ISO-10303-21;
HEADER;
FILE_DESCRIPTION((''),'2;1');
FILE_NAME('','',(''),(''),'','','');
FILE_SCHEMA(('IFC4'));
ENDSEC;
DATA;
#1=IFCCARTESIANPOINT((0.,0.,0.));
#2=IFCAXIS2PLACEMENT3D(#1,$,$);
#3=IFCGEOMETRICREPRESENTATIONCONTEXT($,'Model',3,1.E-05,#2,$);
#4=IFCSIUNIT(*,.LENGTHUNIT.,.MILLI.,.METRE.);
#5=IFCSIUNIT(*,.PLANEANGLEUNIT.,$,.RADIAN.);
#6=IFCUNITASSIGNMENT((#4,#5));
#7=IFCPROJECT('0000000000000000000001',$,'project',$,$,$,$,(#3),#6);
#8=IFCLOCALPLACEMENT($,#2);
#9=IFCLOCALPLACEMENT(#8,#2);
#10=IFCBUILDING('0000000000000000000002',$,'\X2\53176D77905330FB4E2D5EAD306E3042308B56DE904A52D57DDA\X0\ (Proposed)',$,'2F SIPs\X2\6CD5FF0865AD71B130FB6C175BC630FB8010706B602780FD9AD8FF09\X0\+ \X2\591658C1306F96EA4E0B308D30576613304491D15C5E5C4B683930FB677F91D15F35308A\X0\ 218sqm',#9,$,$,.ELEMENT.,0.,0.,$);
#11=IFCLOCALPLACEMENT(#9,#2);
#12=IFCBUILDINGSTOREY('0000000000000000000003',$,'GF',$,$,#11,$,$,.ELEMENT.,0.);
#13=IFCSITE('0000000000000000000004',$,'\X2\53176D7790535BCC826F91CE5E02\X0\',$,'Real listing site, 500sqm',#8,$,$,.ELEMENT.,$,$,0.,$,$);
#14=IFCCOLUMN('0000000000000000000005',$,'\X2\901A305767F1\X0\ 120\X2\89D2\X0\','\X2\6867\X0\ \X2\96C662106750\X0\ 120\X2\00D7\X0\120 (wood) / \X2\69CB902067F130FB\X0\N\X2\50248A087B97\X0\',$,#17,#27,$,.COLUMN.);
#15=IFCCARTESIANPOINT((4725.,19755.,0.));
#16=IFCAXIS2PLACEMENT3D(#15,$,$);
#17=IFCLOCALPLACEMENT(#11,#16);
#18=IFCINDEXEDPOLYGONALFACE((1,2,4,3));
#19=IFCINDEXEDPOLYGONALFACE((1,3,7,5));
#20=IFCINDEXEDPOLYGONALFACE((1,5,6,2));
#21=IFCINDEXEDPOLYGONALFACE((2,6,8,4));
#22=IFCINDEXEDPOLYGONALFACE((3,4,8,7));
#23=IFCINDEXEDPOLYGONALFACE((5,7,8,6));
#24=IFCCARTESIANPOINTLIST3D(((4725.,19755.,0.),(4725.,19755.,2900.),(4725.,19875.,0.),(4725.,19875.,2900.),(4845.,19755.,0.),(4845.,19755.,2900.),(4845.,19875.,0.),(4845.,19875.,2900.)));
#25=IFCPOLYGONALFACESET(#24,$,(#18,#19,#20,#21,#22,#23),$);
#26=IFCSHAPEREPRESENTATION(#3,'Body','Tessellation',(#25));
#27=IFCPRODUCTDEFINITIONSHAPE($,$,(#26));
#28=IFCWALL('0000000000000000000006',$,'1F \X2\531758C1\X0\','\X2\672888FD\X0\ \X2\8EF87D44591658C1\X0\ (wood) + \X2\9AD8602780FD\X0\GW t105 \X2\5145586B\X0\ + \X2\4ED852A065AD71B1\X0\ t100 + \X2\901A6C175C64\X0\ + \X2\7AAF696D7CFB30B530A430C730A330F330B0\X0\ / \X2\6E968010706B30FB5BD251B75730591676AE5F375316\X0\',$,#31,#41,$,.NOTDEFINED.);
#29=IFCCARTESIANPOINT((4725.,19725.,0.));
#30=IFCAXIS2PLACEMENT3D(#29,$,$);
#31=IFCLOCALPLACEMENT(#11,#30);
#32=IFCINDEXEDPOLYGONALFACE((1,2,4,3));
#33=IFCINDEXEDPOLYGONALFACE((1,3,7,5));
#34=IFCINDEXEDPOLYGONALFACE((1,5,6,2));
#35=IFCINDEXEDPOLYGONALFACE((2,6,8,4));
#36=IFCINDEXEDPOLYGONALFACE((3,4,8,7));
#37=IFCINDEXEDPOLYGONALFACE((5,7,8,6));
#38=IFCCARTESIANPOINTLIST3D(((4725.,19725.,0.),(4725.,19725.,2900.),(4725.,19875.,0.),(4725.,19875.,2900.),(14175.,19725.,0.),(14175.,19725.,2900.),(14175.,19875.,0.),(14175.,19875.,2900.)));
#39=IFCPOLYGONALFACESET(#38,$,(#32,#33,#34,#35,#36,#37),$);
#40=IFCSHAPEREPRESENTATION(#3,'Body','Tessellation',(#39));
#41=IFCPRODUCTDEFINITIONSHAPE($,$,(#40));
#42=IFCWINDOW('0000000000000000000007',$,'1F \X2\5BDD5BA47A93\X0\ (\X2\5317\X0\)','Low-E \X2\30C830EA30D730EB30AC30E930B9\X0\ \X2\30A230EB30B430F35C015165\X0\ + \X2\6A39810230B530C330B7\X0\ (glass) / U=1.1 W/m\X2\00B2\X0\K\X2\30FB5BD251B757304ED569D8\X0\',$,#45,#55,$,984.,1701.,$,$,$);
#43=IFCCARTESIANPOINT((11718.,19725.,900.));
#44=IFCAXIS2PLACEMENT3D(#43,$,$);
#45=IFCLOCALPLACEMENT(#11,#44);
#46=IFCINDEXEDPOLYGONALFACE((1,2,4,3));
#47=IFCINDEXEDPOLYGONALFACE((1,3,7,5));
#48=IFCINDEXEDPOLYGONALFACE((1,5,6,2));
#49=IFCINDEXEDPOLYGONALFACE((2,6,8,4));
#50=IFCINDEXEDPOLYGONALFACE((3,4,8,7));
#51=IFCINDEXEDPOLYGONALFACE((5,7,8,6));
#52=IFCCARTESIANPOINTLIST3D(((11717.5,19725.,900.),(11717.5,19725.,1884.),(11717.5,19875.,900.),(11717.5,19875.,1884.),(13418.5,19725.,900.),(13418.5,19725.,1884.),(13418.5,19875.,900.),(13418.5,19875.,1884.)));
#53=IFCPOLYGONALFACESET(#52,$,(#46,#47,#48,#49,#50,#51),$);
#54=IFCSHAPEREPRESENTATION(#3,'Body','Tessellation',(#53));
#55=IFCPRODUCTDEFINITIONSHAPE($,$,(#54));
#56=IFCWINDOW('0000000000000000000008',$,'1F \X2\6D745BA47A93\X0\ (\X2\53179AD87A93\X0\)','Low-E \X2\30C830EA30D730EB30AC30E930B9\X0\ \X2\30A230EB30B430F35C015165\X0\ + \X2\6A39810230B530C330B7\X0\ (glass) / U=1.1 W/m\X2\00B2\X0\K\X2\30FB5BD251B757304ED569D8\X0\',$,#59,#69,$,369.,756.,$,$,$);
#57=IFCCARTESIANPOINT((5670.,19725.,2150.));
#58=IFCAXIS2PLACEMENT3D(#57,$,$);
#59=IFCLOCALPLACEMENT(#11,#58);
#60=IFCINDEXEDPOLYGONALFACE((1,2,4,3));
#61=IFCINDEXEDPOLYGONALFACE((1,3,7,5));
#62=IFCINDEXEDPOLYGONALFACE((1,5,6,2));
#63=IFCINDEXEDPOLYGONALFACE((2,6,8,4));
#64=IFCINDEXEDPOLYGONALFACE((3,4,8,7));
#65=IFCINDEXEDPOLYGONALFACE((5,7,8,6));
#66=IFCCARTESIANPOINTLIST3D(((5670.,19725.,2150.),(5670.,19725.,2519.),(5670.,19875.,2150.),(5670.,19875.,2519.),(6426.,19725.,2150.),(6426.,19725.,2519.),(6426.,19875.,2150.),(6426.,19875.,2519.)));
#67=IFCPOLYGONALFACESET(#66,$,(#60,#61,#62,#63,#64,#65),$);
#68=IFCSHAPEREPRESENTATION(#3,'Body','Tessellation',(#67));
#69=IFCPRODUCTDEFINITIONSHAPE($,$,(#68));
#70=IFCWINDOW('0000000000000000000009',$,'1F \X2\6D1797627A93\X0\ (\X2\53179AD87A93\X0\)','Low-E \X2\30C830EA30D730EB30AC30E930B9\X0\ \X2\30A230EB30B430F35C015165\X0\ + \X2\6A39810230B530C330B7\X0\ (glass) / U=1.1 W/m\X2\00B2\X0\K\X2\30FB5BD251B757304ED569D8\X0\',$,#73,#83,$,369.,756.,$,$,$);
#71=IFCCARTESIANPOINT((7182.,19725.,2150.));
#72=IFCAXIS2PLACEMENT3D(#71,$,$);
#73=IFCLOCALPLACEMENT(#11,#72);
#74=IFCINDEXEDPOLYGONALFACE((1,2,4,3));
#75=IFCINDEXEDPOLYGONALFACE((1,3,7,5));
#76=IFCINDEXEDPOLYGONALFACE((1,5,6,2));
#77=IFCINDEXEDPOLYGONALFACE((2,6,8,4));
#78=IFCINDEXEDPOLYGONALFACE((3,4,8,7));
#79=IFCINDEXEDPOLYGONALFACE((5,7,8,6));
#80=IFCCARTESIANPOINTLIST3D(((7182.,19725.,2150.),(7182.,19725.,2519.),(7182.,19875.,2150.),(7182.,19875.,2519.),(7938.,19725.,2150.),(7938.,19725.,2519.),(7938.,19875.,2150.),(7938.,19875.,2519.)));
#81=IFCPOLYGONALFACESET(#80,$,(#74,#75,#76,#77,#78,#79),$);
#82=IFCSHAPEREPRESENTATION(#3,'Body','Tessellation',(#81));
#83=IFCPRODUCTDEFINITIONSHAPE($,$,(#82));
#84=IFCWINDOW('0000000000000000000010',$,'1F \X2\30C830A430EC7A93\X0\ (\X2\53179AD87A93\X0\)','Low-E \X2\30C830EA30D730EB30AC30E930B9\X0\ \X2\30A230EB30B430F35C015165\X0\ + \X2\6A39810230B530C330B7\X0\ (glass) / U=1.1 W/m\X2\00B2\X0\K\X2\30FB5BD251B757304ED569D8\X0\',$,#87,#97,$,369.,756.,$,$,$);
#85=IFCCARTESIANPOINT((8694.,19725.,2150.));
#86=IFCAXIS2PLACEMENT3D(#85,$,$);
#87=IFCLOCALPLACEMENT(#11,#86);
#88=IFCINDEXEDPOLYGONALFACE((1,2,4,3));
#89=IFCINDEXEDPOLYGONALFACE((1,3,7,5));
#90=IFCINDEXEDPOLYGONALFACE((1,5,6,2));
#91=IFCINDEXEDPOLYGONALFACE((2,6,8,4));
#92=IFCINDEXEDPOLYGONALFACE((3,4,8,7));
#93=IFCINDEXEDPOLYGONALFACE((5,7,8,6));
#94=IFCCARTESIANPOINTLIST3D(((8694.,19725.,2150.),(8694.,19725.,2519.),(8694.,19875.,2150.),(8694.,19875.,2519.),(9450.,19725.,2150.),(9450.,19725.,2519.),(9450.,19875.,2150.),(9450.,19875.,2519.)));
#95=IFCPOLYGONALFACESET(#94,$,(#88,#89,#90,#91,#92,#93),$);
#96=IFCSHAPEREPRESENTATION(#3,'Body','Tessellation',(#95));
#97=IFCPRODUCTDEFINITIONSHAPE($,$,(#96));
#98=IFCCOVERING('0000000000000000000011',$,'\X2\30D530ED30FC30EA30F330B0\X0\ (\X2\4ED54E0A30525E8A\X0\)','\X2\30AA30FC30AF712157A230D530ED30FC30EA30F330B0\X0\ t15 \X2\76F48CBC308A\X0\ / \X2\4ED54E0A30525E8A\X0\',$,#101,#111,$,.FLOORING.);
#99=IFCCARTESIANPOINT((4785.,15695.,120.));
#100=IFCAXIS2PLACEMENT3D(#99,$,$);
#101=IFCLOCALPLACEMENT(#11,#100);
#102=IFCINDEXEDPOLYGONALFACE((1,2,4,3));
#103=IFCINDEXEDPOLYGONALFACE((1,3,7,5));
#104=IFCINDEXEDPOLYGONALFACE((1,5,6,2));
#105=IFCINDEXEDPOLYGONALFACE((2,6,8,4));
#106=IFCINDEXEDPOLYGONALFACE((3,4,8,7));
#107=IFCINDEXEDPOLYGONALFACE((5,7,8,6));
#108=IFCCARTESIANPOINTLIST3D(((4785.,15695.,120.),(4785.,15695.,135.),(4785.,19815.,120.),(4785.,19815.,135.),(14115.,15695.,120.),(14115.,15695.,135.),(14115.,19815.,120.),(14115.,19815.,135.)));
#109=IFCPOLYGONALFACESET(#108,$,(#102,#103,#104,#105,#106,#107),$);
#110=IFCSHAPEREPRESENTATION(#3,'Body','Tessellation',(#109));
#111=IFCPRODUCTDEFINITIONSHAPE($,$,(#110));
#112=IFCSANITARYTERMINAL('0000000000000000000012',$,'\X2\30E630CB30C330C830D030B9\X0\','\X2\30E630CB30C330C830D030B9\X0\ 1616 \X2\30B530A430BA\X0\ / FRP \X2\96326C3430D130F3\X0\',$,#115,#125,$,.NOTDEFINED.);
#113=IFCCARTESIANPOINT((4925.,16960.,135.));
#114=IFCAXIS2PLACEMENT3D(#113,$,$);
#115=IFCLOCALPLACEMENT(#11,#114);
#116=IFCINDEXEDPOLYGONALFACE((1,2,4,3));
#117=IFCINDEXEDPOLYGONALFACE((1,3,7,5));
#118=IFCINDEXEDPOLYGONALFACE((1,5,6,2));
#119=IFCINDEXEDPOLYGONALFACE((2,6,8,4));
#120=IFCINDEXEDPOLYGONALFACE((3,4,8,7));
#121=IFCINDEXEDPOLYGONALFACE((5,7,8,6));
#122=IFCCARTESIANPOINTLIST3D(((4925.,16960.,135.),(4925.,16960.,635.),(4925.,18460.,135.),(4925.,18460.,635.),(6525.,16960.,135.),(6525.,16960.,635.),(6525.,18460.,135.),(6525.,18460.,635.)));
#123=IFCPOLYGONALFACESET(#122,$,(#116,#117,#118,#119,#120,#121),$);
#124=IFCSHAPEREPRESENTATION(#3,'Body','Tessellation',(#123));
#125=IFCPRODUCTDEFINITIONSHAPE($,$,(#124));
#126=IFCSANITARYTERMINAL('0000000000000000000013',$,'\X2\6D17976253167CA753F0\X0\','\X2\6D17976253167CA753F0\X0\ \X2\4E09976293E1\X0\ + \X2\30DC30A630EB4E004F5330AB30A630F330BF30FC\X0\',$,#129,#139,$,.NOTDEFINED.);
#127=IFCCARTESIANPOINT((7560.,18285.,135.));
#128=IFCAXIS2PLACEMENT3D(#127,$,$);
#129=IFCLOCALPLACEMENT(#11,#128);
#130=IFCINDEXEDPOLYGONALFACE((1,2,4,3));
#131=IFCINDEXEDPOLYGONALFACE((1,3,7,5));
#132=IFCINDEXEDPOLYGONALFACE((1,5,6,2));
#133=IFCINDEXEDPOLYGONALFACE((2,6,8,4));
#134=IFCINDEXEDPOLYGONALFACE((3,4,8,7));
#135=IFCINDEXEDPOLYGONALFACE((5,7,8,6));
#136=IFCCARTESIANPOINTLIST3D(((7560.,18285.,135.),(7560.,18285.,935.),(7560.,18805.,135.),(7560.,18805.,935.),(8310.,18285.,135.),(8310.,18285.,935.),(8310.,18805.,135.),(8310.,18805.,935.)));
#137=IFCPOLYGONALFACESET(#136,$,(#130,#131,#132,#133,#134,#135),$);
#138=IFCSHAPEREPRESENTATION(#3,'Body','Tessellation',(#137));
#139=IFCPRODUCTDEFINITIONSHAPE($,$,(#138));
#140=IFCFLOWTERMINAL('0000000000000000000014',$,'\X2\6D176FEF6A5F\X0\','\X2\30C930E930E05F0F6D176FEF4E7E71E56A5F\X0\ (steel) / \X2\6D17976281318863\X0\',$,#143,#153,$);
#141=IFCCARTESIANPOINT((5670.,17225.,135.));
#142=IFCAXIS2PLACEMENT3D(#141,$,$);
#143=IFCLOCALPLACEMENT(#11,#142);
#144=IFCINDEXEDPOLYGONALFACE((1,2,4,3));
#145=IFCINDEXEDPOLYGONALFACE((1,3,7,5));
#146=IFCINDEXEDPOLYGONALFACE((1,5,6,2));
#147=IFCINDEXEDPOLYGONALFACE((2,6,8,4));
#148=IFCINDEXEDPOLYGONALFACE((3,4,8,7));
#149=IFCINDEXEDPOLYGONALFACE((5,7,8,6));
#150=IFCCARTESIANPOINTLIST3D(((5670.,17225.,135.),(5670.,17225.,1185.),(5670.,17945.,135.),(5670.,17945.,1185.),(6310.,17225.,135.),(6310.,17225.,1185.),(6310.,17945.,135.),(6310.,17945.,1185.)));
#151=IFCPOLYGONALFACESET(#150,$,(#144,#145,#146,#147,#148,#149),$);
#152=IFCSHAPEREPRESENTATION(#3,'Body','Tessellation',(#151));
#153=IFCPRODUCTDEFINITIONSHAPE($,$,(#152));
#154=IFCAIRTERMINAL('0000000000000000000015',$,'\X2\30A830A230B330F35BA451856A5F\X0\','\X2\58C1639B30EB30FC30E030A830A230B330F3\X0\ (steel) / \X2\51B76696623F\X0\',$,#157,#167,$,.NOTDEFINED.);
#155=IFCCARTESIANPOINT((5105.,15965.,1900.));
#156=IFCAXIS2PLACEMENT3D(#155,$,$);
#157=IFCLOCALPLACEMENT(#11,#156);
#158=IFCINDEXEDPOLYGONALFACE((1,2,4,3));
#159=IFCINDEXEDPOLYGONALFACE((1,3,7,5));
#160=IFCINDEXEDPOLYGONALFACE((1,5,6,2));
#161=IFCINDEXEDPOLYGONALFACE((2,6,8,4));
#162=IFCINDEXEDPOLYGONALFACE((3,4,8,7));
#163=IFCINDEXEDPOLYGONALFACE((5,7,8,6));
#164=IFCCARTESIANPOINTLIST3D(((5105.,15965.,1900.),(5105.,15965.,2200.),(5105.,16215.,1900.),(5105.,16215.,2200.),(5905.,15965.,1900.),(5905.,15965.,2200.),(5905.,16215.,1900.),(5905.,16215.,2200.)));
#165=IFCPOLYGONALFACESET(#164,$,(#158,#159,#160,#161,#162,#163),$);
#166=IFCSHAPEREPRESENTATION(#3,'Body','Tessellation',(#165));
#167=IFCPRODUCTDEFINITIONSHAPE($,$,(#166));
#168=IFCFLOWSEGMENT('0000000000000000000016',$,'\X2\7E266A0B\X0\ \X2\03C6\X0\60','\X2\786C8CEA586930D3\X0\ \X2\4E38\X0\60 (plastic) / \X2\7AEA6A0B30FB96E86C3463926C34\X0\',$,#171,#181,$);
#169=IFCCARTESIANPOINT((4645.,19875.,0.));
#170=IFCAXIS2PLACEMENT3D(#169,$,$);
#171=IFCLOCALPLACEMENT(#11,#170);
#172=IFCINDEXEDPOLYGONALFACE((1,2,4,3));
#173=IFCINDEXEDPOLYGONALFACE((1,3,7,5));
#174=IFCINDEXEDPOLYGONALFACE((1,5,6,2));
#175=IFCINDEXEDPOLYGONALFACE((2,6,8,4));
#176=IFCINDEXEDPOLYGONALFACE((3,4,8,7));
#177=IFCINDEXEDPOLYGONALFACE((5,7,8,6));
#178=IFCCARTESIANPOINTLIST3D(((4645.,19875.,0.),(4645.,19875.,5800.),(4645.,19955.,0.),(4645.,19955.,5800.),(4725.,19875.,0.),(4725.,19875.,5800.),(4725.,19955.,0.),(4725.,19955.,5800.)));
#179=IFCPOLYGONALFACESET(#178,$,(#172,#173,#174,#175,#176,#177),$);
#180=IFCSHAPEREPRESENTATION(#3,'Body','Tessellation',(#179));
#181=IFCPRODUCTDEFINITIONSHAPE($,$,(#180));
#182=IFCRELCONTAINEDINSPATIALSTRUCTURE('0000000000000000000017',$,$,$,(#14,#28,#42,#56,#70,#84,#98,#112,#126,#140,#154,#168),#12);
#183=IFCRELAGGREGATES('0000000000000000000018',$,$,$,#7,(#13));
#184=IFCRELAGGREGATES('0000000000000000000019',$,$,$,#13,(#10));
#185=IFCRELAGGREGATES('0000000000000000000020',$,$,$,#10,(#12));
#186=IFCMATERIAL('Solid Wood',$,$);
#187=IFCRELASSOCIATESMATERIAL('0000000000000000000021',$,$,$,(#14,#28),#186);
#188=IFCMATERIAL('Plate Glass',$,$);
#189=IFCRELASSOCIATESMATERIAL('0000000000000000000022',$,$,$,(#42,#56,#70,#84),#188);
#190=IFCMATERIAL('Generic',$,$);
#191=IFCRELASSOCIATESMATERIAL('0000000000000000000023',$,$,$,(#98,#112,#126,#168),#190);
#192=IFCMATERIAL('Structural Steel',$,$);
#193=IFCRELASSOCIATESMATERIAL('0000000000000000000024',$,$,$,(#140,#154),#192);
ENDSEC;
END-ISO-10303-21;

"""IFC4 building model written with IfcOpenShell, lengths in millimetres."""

from ifc_helpers import new_model, si_unit, frame, frame_2d, origin, place, context, project, spatial, rectangle, extrude, material, element, fill, save


model = new_model("IFC4")

# Units and contexts
model_context = context("Model", 3, precision=1e-05, world=origin())
ifc_project = project(units=[si_unit("LENGTHUNIT", "METRE", prefix="MILLI"), si_unit("PLANEANGLEUNIT", "RADIAN")], contexts=[model_context])

# Site, building, storey
site_placement = place(None, origin())
site = spatial("IfcSite", under=ifc_project, at=site_placement, Name="北海道富良野市", ObjectType="Real listing site, 500sqm", CompositionType="ELEMENT", RefElevation=0.0)
building_placement = place(site_placement, origin())
building = spatial("IfcBuilding", under=site, at=building_placement, Name="北海道・中庭のある回遊動線 (Proposed)", ObjectType="2F SIPs法（断熱・気密・耐火性能高）+ 外壁は雪下ろし易い金属屋根・板金張り 218sqm", CompositionType="ELEMENT", ElevationOfRefHeight=0.0, ElevationOfTerrain=0.0)
storey_placement = place(building_placement, origin())
storey = spatial("IfcBuildingStorey", under=building, at=storey_placement, Name="GF", CompositionType="ELEMENT", Elevation=0.0)

# Column
ifc_material_1 = material(Name="Solid Wood")
column_1_placement = place(storey_placement, frame((4725.0, 19755.0, 0.0)))
element("IfcColumn", 1, at=column_1_placement, inside=storey, material=ifc_material_1, Name="通し柱 120角", Description="桧 集成材 120×120 (wood) / 構造柱・N値計算", PredefinedType="COLUMN", context=model_context, shape_type="SweptSolid", body=[
    extrude(rectangle(XDim=120.0, YDim=120.0, at=frame_2d((60.0, 60.0))), frame((4725.0, 19755.0, 0.0)), (0.0, 0.0, 1.0), 2900.0),
])

# Wall, openings, windows
wall_1_placement = place(storey_placement, frame((4725.0, 19725.0, 0.0)))
wall_1 = element("IfcWall", 2, at=wall_1_placement, inside=storey, material=ifc_material_1, Name="1F 北壁", Description="木製 軸組外壁 (wood) + 高性能GW t105 充填 + 付加断熱 t100 + 通気層 + 窯業系サイディング / 準耐火・寒冷地外皮強化", PredefinedType="NOTDEFINED", context=model_context, shape_type="SweptSolid", body=[
    extrude(rectangle(XDim=9450.0, YDim=150.0, at=frame_2d((4725.0, 75.0))), frame((4725.0, 19725.0, 0.0)), (0.0, 0.0, 1.0), 2900.0),
])
opening_1_placement = place(storey_placement, frame((11718.0, 19725.0, 900.0)))
opening_1 = element("IfcOpeningElement", 3, at=opening_1_placement, cuts=wall_1, PredefinedType="NOTDEFINED", context=model_context, shape_type="SweptSolid", body=[
    extrude(rectangle(XDim=1701.0, YDim=150.0, at=frame_2d((850.0, 75.0))), frame((11718.0, 19725.0, 900.0)), (0.0, 0.0, 1.0), 984.0),
])
opening_2_placement = place(storey_placement, frame((5670.0, 19725.0, 2150.0)))
opening_2 = element("IfcOpeningElement", 4, at=opening_2_placement, cuts=wall_1, PredefinedType="NOTDEFINED", context=model_context, shape_type="SweptSolid", body=[
    extrude(rectangle(XDim=756.0, YDim=150.0, at=frame_2d((378.0, 75.0))), frame((5670.0, 19725.0, 2150.0)), (0.0, 0.0, 1.0), 369.0),
])
opening_3_placement = place(storey_placement, frame((7182.0, 19725.0, 2150.0)))
opening_3 = element("IfcOpeningElement", 5, at=opening_3_placement, cuts=wall_1, PredefinedType="NOTDEFINED", context=model_context, shape_type="SweptSolid", body=[
    extrude(rectangle(XDim=756.0, YDim=150.0, at=frame_2d((378.0, 75.0))), frame((7182.0, 19725.0, 2150.0)), (0.0, 0.0, 1.0), 369.0),
])
opening_4_placement = place(storey_placement, frame((8694.0, 19725.0, 2150.0)))
opening_4 = element("IfcOpeningElement", 6, at=opening_4_placement, cuts=wall_1, PredefinedType="NOTDEFINED", context=model_context, shape_type="SweptSolid", body=[
    extrude(rectangle(XDim=756.0, YDim=150.0, at=frame_2d((378.0, 75.0))), frame((8694.0, 19725.0, 2150.0)), (0.0, 0.0, 1.0), 369.0),
])
ifc_material_2 = material(Name="Plate Glass")
window_1_placement = place(storey_placement, frame((11718.0, 19725.0, 900.0)))
window_1 = element("IfcWindow", 7, at=window_1_placement, inside=storey, material=ifc_material_2, Name="1F 寝室窓 (北)", Description="Low-E トリプルガラス アルゴン封入 + 樹脂サッシ (glass) / U=1.1 W/m²K・寒冷地仕様", OverallHeight=984.0, OverallWidth=1701.0, context=model_context, shape_type="SweptSolid", body=[
    extrude(rectangle(XDim=1701.0, YDim=150.0, at=frame_2d((850.0, 75.0))), frame((11718.0, 19725.0, 900.0)), (0.0, 0.0, 1.0), 984.0),
])
fill(opening_1, window_1)
window_2_placement = place(storey_placement, frame((5670.0, 19725.0, 2150.0)))
window_2 = element("IfcWindow", 8, at=window_2_placement, inside=storey, material=ifc_material_2, Name="1F 浴室窓 (北高窓)", Description="Low-E トリプルガラス アルゴン封入 + 樹脂サッシ (glass) / U=1.1 W/m²K・寒冷地仕様", OverallHeight=369.0, OverallWidth=756.0, context=model_context, shape_type="SweptSolid", body=[
    extrude(rectangle(XDim=756.0, YDim=150.0, at=frame_2d((378.0, 75.0))), frame((5670.0, 19725.0, 2150.0)), (0.0, 0.0, 1.0), 369.0),
])
fill(opening_2, window_2)
window_3_placement = place(storey_placement, frame((7182.0, 19725.0, 2150.0)))
window_3 = element("IfcWindow", 9, at=window_3_placement, inside=storey, material=ifc_material_2, Name="1F 洗面窓 (北高窓)", Description="Low-E トリプルガラス アルゴン封入 + 樹脂サッシ (glass) / U=1.1 W/m²K・寒冷地仕様", OverallHeight=369.0, OverallWidth=756.0, context=model_context, shape_type="SweptSolid", body=[
    extrude(rectangle(XDim=756.0, YDim=150.0, at=frame_2d((378.0, 75.0))), frame((7182.0, 19725.0, 2150.0)), (0.0, 0.0, 1.0), 369.0),
])
fill(opening_3, window_3)
window_4_placement = place(storey_placement, frame((8694.0, 19725.0, 2150.0)))
window_4 = element("IfcWindow", 10, at=window_4_placement, inside=storey, material=ifc_material_2, Name="1F トイレ窓 (北高窓)", Description="Low-E トリプルガラス アルゴン封入 + 樹脂サッシ (glass) / U=1.1 W/m²K・寒冷地仕様", OverallHeight=369.0, OverallWidth=756.0, context=model_context, shape_type="SweptSolid", body=[
    extrude(rectangle(XDim=756.0, YDim=150.0, at=frame_2d((378.0, 75.0))), frame((8694.0, 19725.0, 2150.0)), (0.0, 0.0, 1.0), 369.0),
])
fill(opening_4, window_4)

# Covering
ifc_material_3 = material(Name="Generic")
covering_placement = place(storey_placement, frame((4785.0, 15695.0, 120.0)))
element("IfcCovering", 11, at=covering_placement, inside=storey, material=ifc_material_3, Name="フローリング (仕上げ床)", Description="オーク無垢フローリング t15 直貼り / 仕上げ床", PredefinedType="FLOORING", context=model_context, shape_type="SweptSolid", body=[
    extrude(rectangle(XDim=9330.0, YDim=4120.0, at=frame_2d((4665.0, 2060.0))), frame((4785.0, 15695.0, 120.0)), (0.0, 0.0, 1.0), 15.0),
])

# Sanitary terminals
sanitary_terminal_1_placement = place(storey_placement, frame((4925.0, 16960.0, 135.0)))
element("IfcSanitaryTerminal", 12, at=sanitary_terminal_1_placement, inside=storey, material=ifc_material_3, Name="ユニットバス", Description="ユニットバス 1616 サイズ / FRP 防水パン", PredefinedType="NOTDEFINED", context=model_context, shape_type="SweptSolid", body=[
    extrude(rectangle(XDim=1600.0, YDim=1500.0, at=frame_2d((800.0, 750.0))), frame((4925.0, 16960.0, 135.0)), (0.0, 0.0, 1.0), 500.0),
])
sanitary_terminal_2_placement = place(storey_placement, frame((7560.0, 18285.0, 135.0)))
element("IfcSanitaryTerminal", 13, at=sanitary_terminal_2_placement, inside=storey, material=ifc_material_3, Name="洗面化粧台", Description="洗面化粧台 三面鏡 + ボウル一体カウンター", PredefinedType="NOTDEFINED", context=model_context, shape_type="SweptSolid", body=[
    extrude(rectangle(XDim=750.0, YDim=520.0, at=frame_2d((375.0, 260.0))), frame((7560.0, 18285.0, 135.0)), (0.0, 0.0, 1.0), 800.0),
])

# Flow terminal
ifc_material_4 = material(Name="Structural Steel")
flow_terminal_placement = place(storey_placement, frame((5670.0, 17225.0, 135.0)))
element("IfcFlowTerminal", 14, at=flow_terminal_placement, inside=storey, material=ifc_material_4, Name="洗濯機", Description="ドラム式洗濯乾燥機 (steel) / 洗面脱衣", context=model_context, shape_type="SweptSolid", body=[
    extrude(rectangle(XDim=640.0, YDim=720.0, at=frame_2d((320.0, 360.0))), frame((5670.0, 17225.0, 135.0)), (0.0, 0.0, 1.0), 1050.0),
])

# Air terminal
air_terminal_placement = place(storey_placement, frame((5105.0, 15965.0, 1900.0)))
element("IfcAirTerminal", 15, at=air_terminal_placement, inside=storey, material=ifc_material_4, Name="エアコン室内機", Description="壁掛ルームエアコン (steel) / 冷暖房", PredefinedType="NOTDEFINED", context=model_context, shape_type="SweptSolid", body=[
    extrude(rectangle(XDim=800.0, YDim=250.0, at=frame_2d((400.0, 125.0))), frame((5105.0, 15965.0, 1900.0)), (0.0, 0.0, 1.0), 300.0),
])

# Flow segment
flow_segment_placement = place(storey_placement, frame((4645.0, 19875.0, 0.0)))
element("IfcFlowSegment", 16, at=flow_segment_placement, inside=storey, material=ifc_material_3, Name="縦樋 φ60", Description="硬質塩ビ 丸60 (plastic) / 竪樋・雨水排水", context=model_context, shape_type="SweptSolid", body=[
    extrude(rectangle(XDim=80.0, YDim=80.0, at=frame_2d((40.0, 40.0))), frame((4645.0, 19875.0, 0.0)), (0.0, 0.0, 1.0), 5800.0),
])

save(model, "model.ifc")
